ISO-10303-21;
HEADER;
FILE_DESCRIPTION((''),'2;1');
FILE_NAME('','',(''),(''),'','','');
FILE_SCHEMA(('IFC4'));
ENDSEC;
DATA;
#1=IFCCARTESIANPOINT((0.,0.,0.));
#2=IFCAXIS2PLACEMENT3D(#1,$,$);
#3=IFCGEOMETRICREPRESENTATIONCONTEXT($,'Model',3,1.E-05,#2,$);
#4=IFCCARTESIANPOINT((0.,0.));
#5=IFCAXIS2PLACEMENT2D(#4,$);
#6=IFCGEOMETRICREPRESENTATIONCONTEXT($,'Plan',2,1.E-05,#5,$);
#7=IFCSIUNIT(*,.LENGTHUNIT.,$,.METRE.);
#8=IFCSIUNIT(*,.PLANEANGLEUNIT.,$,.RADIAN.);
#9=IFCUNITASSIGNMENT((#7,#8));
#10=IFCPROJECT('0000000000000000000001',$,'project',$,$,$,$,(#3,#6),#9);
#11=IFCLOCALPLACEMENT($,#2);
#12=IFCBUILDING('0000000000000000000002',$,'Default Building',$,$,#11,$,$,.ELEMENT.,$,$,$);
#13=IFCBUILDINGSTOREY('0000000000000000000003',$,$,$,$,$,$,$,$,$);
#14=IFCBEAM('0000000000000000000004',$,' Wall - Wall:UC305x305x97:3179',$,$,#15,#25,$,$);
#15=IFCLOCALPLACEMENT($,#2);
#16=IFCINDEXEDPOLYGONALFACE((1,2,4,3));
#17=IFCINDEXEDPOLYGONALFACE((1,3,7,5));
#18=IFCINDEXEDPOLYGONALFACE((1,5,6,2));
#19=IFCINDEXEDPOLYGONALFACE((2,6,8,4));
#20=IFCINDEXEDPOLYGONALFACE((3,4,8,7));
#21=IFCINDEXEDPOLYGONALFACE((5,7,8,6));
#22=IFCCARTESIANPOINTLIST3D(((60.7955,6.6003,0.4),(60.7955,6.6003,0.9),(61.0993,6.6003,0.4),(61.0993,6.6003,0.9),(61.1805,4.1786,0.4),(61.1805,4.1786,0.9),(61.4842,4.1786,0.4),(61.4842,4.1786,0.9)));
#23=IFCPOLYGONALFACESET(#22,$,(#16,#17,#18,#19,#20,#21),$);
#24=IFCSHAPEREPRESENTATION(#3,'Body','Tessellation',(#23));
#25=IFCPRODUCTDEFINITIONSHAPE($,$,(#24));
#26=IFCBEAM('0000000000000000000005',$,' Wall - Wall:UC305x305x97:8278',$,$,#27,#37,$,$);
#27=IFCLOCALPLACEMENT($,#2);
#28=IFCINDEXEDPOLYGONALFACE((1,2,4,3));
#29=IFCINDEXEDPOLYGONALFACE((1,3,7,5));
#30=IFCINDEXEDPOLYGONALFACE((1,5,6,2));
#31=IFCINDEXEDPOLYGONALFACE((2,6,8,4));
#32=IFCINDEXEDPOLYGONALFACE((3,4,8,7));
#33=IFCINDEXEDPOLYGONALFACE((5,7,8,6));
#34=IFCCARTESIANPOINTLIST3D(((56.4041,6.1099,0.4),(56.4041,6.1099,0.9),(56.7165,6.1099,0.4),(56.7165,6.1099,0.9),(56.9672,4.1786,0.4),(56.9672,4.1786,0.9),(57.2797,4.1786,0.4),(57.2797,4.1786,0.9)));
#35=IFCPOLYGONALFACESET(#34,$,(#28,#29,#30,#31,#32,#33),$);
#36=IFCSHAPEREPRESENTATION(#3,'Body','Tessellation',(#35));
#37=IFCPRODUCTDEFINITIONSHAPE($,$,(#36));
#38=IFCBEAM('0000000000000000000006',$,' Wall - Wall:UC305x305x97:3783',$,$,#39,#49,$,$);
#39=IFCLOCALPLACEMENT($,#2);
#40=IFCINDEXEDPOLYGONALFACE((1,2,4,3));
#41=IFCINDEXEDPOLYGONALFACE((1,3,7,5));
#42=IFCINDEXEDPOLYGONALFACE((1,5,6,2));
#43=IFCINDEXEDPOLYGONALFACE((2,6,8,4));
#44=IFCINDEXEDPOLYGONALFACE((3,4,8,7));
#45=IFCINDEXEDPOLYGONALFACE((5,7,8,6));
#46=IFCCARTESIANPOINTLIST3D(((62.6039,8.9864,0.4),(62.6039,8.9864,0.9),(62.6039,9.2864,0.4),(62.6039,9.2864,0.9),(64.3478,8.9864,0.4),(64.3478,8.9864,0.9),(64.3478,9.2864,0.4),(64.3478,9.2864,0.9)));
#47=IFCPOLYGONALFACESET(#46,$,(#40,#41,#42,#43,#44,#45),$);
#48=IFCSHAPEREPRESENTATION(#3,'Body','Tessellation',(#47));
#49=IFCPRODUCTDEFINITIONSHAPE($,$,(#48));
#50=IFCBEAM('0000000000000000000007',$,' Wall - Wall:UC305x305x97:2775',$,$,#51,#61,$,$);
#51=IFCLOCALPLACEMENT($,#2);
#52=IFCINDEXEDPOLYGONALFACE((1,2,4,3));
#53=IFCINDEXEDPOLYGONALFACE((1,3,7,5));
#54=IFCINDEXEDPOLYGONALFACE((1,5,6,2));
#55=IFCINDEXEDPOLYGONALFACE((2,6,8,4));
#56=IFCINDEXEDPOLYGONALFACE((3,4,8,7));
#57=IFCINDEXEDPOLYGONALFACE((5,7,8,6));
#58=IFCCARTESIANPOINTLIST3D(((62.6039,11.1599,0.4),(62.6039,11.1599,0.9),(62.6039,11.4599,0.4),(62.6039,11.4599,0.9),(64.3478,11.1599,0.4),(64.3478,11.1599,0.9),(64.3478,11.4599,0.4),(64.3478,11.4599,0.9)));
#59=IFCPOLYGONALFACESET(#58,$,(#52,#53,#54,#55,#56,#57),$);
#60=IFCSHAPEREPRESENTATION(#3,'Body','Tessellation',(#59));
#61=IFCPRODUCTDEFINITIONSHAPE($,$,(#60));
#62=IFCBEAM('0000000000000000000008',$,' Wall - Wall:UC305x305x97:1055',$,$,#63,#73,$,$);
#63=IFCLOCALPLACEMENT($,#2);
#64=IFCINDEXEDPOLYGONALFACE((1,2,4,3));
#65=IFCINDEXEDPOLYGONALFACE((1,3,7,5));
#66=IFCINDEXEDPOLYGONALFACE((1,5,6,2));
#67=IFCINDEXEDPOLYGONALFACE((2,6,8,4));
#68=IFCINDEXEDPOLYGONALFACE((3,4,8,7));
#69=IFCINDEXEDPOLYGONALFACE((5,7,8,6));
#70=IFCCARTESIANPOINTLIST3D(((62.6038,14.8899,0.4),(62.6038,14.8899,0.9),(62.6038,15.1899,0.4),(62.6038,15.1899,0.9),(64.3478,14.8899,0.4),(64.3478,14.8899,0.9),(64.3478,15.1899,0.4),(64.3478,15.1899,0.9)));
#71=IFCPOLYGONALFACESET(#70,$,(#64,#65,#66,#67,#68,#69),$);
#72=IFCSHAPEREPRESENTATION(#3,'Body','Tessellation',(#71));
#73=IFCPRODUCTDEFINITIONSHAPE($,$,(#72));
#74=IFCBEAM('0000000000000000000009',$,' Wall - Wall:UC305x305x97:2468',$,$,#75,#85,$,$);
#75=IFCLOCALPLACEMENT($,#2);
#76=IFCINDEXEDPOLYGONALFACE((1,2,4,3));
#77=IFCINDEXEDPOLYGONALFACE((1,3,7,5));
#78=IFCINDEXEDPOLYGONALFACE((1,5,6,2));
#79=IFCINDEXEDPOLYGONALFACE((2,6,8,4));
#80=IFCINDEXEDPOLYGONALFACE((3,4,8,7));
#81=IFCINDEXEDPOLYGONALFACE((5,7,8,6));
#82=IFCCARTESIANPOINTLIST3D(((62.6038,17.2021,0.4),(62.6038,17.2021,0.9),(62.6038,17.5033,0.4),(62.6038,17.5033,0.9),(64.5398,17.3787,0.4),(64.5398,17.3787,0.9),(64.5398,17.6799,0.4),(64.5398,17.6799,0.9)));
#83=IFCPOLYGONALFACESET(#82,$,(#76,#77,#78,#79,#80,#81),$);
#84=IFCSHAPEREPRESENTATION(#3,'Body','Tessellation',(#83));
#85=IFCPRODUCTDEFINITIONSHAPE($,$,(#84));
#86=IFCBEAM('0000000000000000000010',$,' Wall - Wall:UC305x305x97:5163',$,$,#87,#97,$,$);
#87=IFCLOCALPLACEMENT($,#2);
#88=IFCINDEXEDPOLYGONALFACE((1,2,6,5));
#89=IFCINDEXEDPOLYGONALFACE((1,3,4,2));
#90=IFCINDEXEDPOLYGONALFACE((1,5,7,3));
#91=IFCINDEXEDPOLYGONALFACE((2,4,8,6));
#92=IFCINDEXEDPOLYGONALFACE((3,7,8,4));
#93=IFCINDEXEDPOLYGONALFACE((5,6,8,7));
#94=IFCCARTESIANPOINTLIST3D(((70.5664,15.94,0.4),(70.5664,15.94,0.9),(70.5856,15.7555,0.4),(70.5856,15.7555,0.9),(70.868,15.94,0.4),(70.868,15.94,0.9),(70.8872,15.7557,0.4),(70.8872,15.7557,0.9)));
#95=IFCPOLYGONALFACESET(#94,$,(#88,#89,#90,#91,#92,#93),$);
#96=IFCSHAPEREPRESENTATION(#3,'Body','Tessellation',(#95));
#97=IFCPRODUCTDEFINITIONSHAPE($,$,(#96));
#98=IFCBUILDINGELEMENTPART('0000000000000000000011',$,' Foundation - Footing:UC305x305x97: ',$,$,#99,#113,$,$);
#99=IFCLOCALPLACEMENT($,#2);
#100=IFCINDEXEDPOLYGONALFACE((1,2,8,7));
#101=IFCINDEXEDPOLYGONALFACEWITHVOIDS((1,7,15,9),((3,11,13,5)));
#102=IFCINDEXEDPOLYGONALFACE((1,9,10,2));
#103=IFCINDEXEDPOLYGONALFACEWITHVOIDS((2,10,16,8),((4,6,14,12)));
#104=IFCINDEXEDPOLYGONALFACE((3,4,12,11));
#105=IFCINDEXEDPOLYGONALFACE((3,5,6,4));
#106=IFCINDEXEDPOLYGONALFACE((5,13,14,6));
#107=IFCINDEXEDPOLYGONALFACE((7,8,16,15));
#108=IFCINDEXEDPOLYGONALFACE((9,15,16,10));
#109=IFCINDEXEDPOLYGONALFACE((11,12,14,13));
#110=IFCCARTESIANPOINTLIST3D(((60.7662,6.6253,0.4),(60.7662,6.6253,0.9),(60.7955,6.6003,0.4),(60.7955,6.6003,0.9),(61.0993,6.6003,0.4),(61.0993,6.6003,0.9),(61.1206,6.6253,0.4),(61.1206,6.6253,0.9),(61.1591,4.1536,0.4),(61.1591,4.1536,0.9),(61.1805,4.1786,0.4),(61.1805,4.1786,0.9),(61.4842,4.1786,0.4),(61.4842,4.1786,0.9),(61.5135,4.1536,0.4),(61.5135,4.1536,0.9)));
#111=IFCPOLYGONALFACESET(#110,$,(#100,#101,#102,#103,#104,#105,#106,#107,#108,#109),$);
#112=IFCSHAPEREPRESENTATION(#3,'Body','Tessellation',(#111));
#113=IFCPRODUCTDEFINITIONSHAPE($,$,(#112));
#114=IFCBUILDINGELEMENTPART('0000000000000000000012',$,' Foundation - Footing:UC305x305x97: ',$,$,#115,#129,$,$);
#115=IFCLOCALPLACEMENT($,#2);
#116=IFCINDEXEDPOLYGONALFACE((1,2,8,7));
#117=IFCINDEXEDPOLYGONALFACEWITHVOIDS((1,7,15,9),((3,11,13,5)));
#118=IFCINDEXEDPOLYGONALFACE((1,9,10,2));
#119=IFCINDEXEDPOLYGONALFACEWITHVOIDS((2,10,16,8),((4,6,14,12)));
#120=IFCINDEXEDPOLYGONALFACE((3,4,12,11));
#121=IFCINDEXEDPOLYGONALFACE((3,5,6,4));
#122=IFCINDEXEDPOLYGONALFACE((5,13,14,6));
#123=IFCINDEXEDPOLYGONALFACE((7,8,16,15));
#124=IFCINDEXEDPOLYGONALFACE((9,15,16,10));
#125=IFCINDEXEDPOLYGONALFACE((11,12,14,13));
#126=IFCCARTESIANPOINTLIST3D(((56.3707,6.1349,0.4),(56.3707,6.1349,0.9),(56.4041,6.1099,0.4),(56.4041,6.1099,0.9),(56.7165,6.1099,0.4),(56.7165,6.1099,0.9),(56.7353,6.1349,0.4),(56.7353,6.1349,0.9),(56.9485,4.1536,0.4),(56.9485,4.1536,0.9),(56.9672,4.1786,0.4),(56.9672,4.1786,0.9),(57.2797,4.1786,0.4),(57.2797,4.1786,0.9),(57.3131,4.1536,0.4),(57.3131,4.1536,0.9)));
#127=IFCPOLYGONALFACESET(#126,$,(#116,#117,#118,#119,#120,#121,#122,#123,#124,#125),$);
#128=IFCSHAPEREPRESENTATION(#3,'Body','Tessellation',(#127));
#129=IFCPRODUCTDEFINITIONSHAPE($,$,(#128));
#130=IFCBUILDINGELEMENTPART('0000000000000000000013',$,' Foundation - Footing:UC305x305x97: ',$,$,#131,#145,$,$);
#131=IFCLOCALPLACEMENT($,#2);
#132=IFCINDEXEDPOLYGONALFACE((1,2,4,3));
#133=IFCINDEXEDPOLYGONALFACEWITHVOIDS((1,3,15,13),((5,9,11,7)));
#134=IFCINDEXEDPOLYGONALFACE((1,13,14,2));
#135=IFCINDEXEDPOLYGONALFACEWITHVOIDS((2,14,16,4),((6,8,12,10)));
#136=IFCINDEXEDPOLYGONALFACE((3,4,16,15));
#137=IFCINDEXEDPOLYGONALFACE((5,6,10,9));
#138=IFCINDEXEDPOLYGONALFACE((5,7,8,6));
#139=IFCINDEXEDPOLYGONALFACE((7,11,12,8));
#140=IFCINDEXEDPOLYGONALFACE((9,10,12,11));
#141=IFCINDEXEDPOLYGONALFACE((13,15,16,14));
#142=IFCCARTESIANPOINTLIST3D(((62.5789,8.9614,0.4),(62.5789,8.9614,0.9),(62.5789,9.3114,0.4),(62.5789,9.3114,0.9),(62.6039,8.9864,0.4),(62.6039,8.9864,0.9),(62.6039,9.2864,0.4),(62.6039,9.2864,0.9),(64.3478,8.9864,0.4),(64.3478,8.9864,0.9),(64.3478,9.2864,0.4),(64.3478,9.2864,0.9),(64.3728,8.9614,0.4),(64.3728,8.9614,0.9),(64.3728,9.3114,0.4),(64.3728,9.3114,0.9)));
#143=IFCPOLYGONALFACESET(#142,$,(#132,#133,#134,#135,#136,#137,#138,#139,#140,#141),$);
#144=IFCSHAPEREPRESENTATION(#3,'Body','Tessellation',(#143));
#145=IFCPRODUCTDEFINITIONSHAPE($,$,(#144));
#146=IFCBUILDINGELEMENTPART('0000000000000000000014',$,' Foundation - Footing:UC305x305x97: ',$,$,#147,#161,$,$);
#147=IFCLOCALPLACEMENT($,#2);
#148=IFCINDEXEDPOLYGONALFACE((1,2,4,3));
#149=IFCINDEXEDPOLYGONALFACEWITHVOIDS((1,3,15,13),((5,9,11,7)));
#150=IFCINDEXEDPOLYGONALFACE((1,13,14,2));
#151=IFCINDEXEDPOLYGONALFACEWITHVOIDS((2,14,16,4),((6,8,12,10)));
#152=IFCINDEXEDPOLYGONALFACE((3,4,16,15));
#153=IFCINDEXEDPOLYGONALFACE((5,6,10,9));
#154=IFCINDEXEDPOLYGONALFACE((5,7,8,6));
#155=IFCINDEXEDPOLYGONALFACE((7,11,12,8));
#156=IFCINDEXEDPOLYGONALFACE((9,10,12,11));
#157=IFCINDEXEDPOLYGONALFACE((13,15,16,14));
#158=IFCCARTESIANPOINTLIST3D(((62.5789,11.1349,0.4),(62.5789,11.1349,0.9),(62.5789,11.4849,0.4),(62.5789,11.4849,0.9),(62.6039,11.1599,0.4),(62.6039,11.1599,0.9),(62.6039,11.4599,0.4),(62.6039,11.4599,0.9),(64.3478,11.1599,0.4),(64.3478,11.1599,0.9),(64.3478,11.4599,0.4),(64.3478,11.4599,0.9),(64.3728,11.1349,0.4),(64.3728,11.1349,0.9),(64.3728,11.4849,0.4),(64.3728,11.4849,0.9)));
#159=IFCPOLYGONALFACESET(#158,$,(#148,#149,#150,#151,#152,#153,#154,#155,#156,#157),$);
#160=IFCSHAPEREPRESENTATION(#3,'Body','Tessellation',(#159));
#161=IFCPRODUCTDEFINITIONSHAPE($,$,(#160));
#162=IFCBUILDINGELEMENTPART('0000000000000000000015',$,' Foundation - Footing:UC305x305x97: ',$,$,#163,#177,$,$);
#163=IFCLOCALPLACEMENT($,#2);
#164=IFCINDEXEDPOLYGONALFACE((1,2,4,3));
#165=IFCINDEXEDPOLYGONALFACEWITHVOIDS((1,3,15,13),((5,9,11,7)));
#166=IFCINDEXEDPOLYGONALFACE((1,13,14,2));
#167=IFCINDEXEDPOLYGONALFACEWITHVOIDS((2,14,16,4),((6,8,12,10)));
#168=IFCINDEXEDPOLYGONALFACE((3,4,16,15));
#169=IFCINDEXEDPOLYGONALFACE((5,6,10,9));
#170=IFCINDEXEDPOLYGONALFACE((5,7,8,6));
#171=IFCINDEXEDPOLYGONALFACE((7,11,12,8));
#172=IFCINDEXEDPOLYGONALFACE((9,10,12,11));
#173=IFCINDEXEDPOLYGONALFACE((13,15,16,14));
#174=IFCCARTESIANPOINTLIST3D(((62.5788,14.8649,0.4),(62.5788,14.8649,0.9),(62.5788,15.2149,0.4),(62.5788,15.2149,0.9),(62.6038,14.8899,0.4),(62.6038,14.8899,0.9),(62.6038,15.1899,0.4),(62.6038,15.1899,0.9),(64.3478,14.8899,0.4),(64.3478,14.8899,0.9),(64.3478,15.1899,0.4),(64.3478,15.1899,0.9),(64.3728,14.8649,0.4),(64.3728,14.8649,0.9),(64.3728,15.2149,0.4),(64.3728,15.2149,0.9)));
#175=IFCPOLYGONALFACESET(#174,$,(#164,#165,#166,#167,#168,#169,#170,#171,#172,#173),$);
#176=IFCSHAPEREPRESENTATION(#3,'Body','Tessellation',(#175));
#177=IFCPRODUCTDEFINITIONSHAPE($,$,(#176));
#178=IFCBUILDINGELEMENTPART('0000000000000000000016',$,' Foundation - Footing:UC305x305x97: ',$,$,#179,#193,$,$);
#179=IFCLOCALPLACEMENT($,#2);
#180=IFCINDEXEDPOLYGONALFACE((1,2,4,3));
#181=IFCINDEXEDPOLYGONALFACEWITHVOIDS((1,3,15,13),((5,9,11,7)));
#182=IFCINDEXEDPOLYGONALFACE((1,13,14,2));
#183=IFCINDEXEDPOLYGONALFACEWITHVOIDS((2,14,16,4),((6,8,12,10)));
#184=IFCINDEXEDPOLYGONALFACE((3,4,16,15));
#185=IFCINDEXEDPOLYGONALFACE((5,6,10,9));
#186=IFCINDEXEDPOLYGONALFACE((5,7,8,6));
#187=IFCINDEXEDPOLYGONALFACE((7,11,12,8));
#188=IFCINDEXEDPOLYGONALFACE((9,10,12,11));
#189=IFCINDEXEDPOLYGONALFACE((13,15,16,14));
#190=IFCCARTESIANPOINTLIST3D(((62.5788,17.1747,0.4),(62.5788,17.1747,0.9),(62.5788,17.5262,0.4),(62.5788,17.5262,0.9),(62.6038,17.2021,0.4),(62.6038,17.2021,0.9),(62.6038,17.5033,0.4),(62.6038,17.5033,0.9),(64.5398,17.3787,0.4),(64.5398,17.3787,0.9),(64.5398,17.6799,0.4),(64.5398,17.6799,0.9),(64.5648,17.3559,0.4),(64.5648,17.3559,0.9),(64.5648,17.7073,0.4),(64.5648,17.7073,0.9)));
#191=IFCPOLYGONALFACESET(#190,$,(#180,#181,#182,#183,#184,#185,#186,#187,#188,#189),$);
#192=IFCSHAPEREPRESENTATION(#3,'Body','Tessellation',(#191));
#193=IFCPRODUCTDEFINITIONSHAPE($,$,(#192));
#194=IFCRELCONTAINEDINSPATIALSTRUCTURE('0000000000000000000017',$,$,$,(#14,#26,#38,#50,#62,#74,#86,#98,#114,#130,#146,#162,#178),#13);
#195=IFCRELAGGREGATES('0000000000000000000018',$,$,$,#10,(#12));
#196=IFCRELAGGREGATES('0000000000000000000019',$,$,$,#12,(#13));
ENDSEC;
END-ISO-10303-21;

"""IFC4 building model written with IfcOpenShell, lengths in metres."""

from ifc_helpers import new_model, si_unit, origin, origin_2d, place, context, project, spatial, polyline, outline, extrude, element, save


model = new_model("IFC4")

# Units and contexts
model_context = context("Model", 3, precision=1e-05, world=origin())
plan_context = context("Plan", 2, precision=1e-05, world=origin_2d())
ifc_project = project(units=[si_unit("LENGTHUNIT", "METRE"), si_unit("PLANEANGLEUNIT", "RADIAN")], contexts=[model_context, plan_context])

# Building, storey
building_placement = place(None, origin())
building = spatial("IfcBuilding", under=ifc_project, at=building_placement, Name="Default Building", CompositionType="ELEMENT")
storey = spatial("IfcBuildingStorey", under=building)

# Beams
element("IfcBeam", 1, inside=storey, Name=" Wall - Wall:UC305x305x97:3179", context=model_context, shape_type="SweptSolid", body=[
    extrude(outline(polyline([(61.4842, 4.1786, 0.4), (61.0993, 6.6003, 0.4), (60.7955, 6.6003, 0.4), (61.1805, 4.1786, 0.4), (61.4842, 4.1786, 0.4)])), None, (0.0, 0.0, 1.0), 0.5),
])
element("IfcBeam", 2, inside=storey, Name=" Wall - Wall:UC305x305x97:8278", context=model_context, shape_type="SweptSolid", body=[
    extrude(outline(polyline([(56.9672, 4.1786, 0.4), (57.2797, 4.1786, 0.4), (56.7165, 6.1099, 0.4), (56.4041, 6.1099, 0.4), (56.9672, 4.1786, 0.4)])), None, (0.0, 0.0, 1.0), 0.5),
])
element("IfcBeam", 3, inside=storey, Name=" Wall - Wall:UC305x305x97:3783", context=model_context, shape_type="SweptSolid", body=[
    extrude(outline(polyline([(64.3478, 8.9864, 0.4), (62.6039, 8.9864, 0.4), (62.6039, 9.2864, 0.4), (64.3478, 9.2864, 0.4), (64.3478, 8.9864, 0.4)])), None, (0.0, 0.0, 1.0), 0.5),
])
element("IfcBeam", 4, inside=storey, Name=" Wall - Wall:UC305x305x97:2775", context=model_context, shape_type="SweptSolid", body=[
    extrude(outline(polyline([(64.3478, 11.1599, 0.4), (64.3478, 11.4599, 0.4), (62.6039, 11.4599, 0.4), (62.6039, 11.1599, 0.4), (64.3478, 11.1599, 0.4)])), None, (0.0, 0.0, 1.0), 0.5),
])
element("IfcBeam", 5, inside=storey, Name=" Wall - Wall:UC305x305x97:1055", context=model_context, shape_type="SweptSolid", body=[
    extrude(outline(polyline([(64.3478, 14.8899, 0.4), (64.3478, 15.1899, 0.4), (62.6038, 15.1899, 0.4), (62.6038, 14.8899, 0.4), (64.3478, 14.8899, 0.4)])), None, (0.0, 0.0, 1.0), 0.5),
])
element("IfcBeam", 6, inside=storey, Name=" Wall - Wall:UC305x305x97:2468", context=model_context, shape_type="SweptSolid", body=[
    extrude(outline(polyline([(64.5398, 17.3787, 0.4), (64.5398, 17.6799, 0.4), (62.6038, 17.5033, 0.4), (62.6038, 17.2021, 0.4), (64.5398, 17.3787, 0.4)])), None, (0.0, 0.0, 1.0), 0.5),
])
element("IfcBeam", 7, inside=storey, Name=" Wall - Wall:UC305x305x97:5163", context=model_context, shape_type="SweptSolid", body=[
    extrude(outline(polyline([(70.8872, 15.7557, 0.4), (70.868, 15.94, 0.4), (70.5664, 15.94, 0.4), (70.5856, 15.7555, 0.4), (70.8872, 15.7557, 0.4)])), None, (0.0, 0.0, 1.0), 0.5),
])

# Building element parts, openings
building_element_part_1 = element("IfcBuildingElementPart", 8, inside=storey, Name=" Foundation - Footing:UC305x305x97: ", context=model_context, shape_type="SweptSolid", body=[
    extrude(outline(polyline([(61.5135, 4.1536, 0.4), (61.1206, 6.6253, 0.4), (60.7662, 6.6253, 0.4), (61.1591, 4.1536, 0.4), (61.5135, 4.1536, 0.4)])), None, (0.0, 0.0, 1.0), 0.5),
])
element("IfcOpeningElement", 9, inside=storey, cuts=building_element_part_1, context=model_context, shape_type="SweptSolid", body=[
    extrude(outline(polyline([(61.4842, 4.1786, 0.4), (61.0993, 6.6003, 0.4), (60.7955, 6.6003, 0.4), (61.1805, 4.1786, 0.4), (61.4842, 4.1786, 0.4)])), None, (0.0, 0.0, 1.0), 0.5),
])
building_element_part_2 = element("IfcBuildingElementPart", 10, inside=storey, Name=" Foundation - Footing:UC305x305x97: ", context=model_context, shape_type="SweptSolid", body=[
    extrude(outline(polyline([(56.9485, 4.1536, 0.4), (57.3131, 4.1536, 0.4), (56.7353, 6.1349, 0.4), (56.3707, 6.1349, 0.4), (56.9485, 4.1536, 0.4)])), None, (0.0, 0.0, 1.0), 0.5),
])
element("IfcOpeningElement", 11, inside=storey, cuts=building_element_part_2, context=model_context, shape_type="SweptSolid", body=[
    extrude(outline(polyline([(56.9672, 4.1786, 0.4), (57.2797, 4.1786, 0.4), (56.7165, 6.1099, 0.4), (56.4041, 6.1099, 0.4), (56.9672, 4.1786, 0.4)])), None, (0.0, 0.0, 1.0), 0.5),
])
building_element_part_3 = element("IfcBuildingElementPart", 12, inside=storey, Name=" Foundation - Footing:UC305x305x97: ", context=model_context, shape_type="SweptSolid", body=[
    extrude(outline(polyline([(64.3728, 8.9614, 0.4), (62.5789, 8.9614, 0.4), (62.5789, 9.3114, 0.4), (64.3728, 9.3114, 0.4), (64.3728, 8.9614, 0.4)])), None, (0.0, 0.0, 1.0), 0.5),
])
element("IfcOpeningElement", 13, inside=storey, cuts=building_element_part_3, context=model_context, shape_type="SweptSolid", body=[
    extrude(outline(polyline([(64.3478, 8.9864, 0.4), (62.6039, 8.9864, 0.4), (62.6039, 9.2864, 0.4), (64.3478, 9.2864, 0.4), (64.3478, 8.9864, 0.4)])), None, (0.0, 0.0, 1.0), 0.5),
])
building_element_part_4 = element("IfcBuildingElementPart", 14, inside=storey, Name=" Foundation - Footing:UC305x305x97: ", context=model_context, shape_type="SweptSolid", body=[
    extrude(outline(polyline([(64.3728, 11.1349, 0.4), (64.3728, 11.4849, 0.4), (62.5789, 11.4849, 0.4), (62.5789, 11.1349, 0.4), (64.3728, 11.1349, 0.4)])), None, (0.0, 0.0, 1.0), 0.5),
])
element("IfcOpeningElement", 15, inside=storey, cuts=building_element_part_4, context=model_context, shape_type="SweptSolid", body=[
    extrude(outline(polyline([(64.3478, 11.1599, 0.4), (64.3478, 11.4599, 0.4), (62.6039, 11.4599, 0.4), (62.6039, 11.1599, 0.4), (64.3478, 11.1599, 0.4)])), None, (0.0, 0.0, 1.0), 0.5),
])
building_element_part_5 = element("IfcBuildingElementPart", 16, inside=storey, Name=" Foundation - Footing:UC305x305x97: ", context=model_context, shape_type="SweptSolid", body=[
    extrude(outline(polyline([(64.3728, 14.8649, 0.4), (64.3728, 15.2149, 0.4), (62.5788, 15.2149, 0.4), (62.5788, 14.8649, 0.4), (64.3728, 14.8649, 0.4)])), None, (0.0, 0.0, 1.0), 0.5),
])
element("IfcOpeningElement", 17, inside=storey, cuts=building_element_part_5, context=model_context, shape_type="SweptSolid", body=[
    extrude(outline(polyline([(64.3478, 14.8899, 0.4), (64.3478, 15.1899, 0.4), (62.6038, 15.1899, 0.4), (62.6038, 14.8899, 0.4), (64.3478, 14.8899, 0.4)])), None, (0.0, 0.0, 1.0), 0.5),
])
building_element_part_6 = element("IfcBuildingElementPart", 18, inside=storey, Name=" Foundation - Footing:UC305x305x97: ", context=model_context, shape_type="SweptSolid", body=[
    extrude(outline(polyline([(64.5648, 17.3559, 0.4), (64.5648, 17.7073, 0.4), (62.5788, 17.5262, 0.4), (62.5788, 17.1747, 0.4), (64.5648, 17.3559, 0.4)])), None, (0.0, 0.0, 1.0), 0.5),
])
element("IfcOpeningElement", 19, inside=storey, cuts=building_element_part_6, context=model_context, shape_type="SweptSolid", body=[
    extrude(outline(polyline([(64.5398, 17.3787, 0.4), (64.5398, 17.6799, 0.4), (62.6038, 17.5033, 0.4), (62.6038, 17.2021, 0.4), (64.5398, 17.3787, 0.4)])), None, (0.0, 0.0, 1.0), 0.5),
])

save(model, "model.ifc")
